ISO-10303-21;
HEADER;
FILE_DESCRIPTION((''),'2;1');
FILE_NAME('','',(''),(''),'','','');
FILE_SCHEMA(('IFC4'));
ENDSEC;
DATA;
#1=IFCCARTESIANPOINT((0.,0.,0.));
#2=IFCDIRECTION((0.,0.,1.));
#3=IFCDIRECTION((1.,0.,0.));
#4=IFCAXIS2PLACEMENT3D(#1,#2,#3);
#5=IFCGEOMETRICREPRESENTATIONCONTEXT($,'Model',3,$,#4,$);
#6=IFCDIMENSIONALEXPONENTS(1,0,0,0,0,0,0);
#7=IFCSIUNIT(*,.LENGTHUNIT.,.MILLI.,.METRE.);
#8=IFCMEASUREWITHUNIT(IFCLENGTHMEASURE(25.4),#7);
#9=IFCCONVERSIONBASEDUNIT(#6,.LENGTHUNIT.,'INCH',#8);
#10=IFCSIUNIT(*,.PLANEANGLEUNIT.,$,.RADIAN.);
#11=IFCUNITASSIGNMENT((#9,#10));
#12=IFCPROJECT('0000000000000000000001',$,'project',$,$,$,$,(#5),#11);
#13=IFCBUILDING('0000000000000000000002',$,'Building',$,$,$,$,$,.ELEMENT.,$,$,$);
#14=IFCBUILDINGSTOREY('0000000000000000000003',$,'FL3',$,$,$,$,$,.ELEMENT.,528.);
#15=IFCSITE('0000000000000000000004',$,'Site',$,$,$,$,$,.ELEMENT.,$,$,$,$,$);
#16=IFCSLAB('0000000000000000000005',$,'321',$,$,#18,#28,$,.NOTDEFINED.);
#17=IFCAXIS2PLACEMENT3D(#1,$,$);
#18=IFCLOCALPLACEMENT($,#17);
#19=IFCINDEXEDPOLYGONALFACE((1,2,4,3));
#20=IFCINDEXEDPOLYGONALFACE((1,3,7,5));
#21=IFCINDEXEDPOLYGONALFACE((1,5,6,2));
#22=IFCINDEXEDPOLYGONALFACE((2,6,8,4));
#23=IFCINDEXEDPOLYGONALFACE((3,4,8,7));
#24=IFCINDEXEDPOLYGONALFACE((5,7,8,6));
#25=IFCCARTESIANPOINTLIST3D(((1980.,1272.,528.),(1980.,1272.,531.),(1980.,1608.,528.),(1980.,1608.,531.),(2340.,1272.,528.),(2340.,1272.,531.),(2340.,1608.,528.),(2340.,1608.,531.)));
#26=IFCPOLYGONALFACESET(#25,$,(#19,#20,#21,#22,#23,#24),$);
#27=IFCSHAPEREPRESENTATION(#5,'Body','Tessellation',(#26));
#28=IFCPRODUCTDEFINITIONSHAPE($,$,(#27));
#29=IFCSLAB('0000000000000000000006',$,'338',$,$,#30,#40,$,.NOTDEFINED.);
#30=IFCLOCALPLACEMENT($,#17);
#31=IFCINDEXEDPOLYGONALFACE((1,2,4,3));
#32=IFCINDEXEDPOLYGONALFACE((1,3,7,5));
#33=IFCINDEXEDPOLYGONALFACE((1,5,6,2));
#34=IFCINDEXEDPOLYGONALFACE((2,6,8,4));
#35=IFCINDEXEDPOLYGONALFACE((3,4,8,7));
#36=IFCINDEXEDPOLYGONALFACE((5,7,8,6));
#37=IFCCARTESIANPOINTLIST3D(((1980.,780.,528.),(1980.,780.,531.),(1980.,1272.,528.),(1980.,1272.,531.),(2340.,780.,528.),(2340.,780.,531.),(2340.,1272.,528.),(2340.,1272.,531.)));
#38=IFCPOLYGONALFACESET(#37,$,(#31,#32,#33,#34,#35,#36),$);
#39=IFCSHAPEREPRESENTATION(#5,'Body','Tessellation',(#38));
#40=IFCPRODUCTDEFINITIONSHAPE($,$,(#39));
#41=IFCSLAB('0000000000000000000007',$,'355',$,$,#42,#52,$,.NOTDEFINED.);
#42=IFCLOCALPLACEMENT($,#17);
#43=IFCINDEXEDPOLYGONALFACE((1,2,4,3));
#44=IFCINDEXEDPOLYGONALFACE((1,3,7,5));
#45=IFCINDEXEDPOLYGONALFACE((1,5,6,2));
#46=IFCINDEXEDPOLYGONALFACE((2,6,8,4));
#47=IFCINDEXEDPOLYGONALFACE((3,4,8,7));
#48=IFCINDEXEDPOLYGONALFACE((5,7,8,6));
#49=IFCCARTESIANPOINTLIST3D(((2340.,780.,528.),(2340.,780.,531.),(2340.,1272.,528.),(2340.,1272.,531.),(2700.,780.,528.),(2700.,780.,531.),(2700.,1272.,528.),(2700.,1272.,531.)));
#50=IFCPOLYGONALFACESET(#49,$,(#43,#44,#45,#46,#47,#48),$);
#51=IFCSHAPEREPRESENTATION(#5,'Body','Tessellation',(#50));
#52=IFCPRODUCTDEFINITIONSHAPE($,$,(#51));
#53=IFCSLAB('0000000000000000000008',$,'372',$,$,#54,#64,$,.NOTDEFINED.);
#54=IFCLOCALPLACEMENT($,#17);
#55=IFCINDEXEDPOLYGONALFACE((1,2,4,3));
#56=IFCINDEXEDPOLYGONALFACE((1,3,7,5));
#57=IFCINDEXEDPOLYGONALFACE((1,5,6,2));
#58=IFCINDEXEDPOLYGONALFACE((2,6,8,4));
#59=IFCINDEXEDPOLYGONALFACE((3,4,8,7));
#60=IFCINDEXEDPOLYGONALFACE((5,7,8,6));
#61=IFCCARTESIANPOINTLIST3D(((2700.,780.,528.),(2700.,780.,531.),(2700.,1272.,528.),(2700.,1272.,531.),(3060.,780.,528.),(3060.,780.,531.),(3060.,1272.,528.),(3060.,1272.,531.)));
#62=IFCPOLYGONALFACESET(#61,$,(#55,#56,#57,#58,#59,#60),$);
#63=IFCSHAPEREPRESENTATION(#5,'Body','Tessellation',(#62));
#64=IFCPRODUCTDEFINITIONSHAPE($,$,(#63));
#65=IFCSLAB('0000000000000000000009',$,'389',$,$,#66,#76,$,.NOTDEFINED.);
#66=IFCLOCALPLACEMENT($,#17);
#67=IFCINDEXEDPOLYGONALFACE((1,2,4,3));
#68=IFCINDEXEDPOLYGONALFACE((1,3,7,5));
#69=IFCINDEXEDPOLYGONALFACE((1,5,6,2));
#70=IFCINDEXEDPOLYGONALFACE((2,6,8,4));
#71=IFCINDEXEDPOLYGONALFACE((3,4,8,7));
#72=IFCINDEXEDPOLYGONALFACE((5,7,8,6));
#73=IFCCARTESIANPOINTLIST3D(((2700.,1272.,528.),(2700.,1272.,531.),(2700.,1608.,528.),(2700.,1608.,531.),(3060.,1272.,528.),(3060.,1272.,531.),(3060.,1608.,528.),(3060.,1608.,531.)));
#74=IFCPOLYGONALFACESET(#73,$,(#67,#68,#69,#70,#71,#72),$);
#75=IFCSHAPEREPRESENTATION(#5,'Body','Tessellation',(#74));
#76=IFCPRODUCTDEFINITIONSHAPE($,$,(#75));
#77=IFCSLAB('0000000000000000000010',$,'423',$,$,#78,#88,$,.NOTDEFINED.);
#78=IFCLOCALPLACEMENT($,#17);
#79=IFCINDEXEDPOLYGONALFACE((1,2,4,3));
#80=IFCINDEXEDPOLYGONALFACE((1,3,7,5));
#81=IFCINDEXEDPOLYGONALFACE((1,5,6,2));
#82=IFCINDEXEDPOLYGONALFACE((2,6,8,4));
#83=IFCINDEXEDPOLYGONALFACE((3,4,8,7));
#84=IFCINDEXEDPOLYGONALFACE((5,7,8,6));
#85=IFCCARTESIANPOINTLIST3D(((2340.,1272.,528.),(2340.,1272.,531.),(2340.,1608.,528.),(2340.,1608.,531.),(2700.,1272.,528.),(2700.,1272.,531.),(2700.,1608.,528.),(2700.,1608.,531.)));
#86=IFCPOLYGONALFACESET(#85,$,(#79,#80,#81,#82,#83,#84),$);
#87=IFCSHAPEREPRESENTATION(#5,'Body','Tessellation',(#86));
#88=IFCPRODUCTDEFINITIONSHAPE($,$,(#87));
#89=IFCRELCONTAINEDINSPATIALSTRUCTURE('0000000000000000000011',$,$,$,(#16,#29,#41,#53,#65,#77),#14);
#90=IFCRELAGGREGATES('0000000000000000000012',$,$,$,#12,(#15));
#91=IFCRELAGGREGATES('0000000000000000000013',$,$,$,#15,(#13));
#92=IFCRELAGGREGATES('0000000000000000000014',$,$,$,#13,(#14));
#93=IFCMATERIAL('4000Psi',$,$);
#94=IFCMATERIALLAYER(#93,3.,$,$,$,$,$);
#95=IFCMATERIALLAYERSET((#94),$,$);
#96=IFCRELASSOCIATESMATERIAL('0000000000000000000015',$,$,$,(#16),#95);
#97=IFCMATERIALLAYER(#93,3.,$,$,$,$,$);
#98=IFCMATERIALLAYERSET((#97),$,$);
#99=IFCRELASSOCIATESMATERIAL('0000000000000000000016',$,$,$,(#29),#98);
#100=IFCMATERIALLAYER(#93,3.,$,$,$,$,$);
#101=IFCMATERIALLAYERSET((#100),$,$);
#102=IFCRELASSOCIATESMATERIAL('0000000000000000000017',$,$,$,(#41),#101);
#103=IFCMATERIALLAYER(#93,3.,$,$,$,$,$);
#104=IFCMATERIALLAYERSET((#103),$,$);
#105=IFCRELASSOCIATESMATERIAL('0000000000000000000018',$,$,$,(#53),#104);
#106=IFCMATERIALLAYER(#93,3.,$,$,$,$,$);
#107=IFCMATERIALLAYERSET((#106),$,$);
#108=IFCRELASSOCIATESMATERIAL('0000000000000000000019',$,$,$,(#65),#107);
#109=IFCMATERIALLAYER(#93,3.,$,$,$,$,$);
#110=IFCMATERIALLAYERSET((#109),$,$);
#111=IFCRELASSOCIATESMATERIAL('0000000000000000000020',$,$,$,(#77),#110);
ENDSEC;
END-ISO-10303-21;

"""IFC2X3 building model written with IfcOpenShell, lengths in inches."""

from ifc_helpers import new_model, entity, si_unit, converted_unit, frame, origin_with_axes, place, context, project, spatial, polyline, outline, extrude, material, layer, layer_set, layer_usage, element, save


model = new_model("IFC2X3")

# Units and contexts
model_context = context("Model", 3, world=origin_with_axes())
ifc_project = project(units=[converted_unit("LENGTHUNIT", "INCH", entity("IfcLengthMeasure", 25.4), si_unit("LENGTHUNIT", "METRE", prefix="MILLI"), dimensions=[1, 0, 0, 0, 0, 0, 0]), si_unit("PLANEANGLEUNIT", "RADIAN")], contexts=[model_context])

# Site, building, storey
site = spatial("IfcSite", under=ifc_project, Name="Site", CompositionType="ELEMENT")
building = spatial("IfcBuilding", under=site, Name="Building", CompositionType="ELEMENT")
storey = spatial("IfcBuildingStorey", under=building, Name="FL3", CompositionType="ELEMENT", Elevation=528.0)

# Slabs
ifc_material_1 = material(Name="4000Psi")
ifc_layer_1 = layer(ifc_material_1, 3.0)
ifc_layer_set_1 = layer_set([ifc_layer_1])
ifc_layer_usage_1 = layer_usage(ifc_layer_set_1, "AXIS2", "POSITIVE", -3.0)
slab_1_placement = place(None, frame((1980.0, 1272.0, 528.0), z_axis=(0.0, 0.0, 1.0), x_axis=(1.0, 0.0, 0.0)))
element("IfcSlab", 1, at=slab_1_placement, inside=storey, material=ifc_layer_usage_1, Name="321", PredefinedType="NOTDEFINED", context=model_context, shape_type="SweptSolid", body=[
    extrude(outline(polyline([(0.0, 0.0), (360.0, 0.0), (360.0, 336.0), (0.0, 336.0), (0.0, 0.0)])), origin_with_axes(), (0.0, 0.0, 1.0), 3.0),
])
ifc_layer_2 = layer(ifc_material_1, 3.0)
ifc_layer_set_2 = layer_set([ifc_layer_2])
ifc_layer_usage_2 = layer_usage(ifc_layer_set_2, "AXIS2", "POSITIVE", -3.0)
slab_2_placement = place(None, frame((1980.0, 780.0, 528.0), z_axis=(0.0, 0.0, 1.0), x_axis=(1.0, 0.0, 0.0)))
element("IfcSlab", 2, at=slab_2_placement, inside=storey, material=ifc_layer_usage_2, Name="338", PredefinedType="NOTDEFINED", context=model_context, shape_type="SweptSolid", body=[
    extrude(outline(polyline([(0.0, 0.0), (360.0, 0.0), (360.0, 492.0), (0.0, 492.0), (0.0, 0.0)])), origin_with_axes(), (0.0, 0.0, 1.0), 3.0),
])
ifc_layer_3 = layer(ifc_material_1, 3.0)
ifc_layer_set_3 = layer_set([ifc_layer_3])
ifc_layer_usage_3 = layer_usage(ifc_layer_set_3, "AXIS2", "POSITIVE", -3.0)
slab_3_placement = place(None, frame((2340.0, 780.0, 528.0), z_axis=(0.0, 0.0, 1.0), x_axis=(1.0, 0.0, 0.0)))
element("IfcSlab", 3, at=slab_3_placement, inside=storey, material=ifc_layer_usage_3, Name="355", PredefinedType="NOTDEFINED", context=model_context, shape_type="SweptSolid", body=[
    extrude(outline(polyline([(0.0, 0.0), (360.0, 0.0), (360.0, 492.0), (0.0, 492.0), (0.0, 0.0)])), origin_with_axes(), (0.0, 0.0, 1.0), 3.0),
])
ifc_layer_4 = layer(ifc_material_1, 3.0)
ifc_layer_set_4 = layer_set([ifc_layer_4])
ifc_layer_usage_4 = layer_usage(ifc_layer_set_4, "AXIS2", "POSITIVE", -3.0)
slab_4_placement = place(None, frame((2700.0, 780.0, 528.0), z_axis=(0.0, 0.0, 1.0), x_axis=(1.0, 0.0, 0.0)))
element("IfcSlab", 4, at=slab_4_placement, inside=storey, material=ifc_layer_usage_4, Name="372", PredefinedType="NOTDEFINED", context=model_context, shape_type="SweptSolid", body=[
    extrude(outline(polyline([(0.0, 0.0), (360.0, 0.0), (360.0, 492.0), (0.0, 492.0), (0.0, 0.0)])), origin_with_axes(), (0.0, 0.0, 1.0), 3.0),
])
ifc_layer_5 = layer(ifc_material_1, 3.0)
ifc_layer_set_5 = layer_set([ifc_layer_5])
ifc_layer_usage_5 = layer_usage(ifc_layer_set_5, "AXIS2", "POSITIVE", -3.0)
slab_5_placement = place(None, frame((2700.0, 1272.0, 528.0), z_axis=(0.0, 0.0, 1.0), x_axis=(1.0, 0.0, 0.0)))
element("IfcSlab", 5, at=slab_5_placement, inside=storey, material=ifc_layer_usage_5, Name="389", PredefinedType="NOTDEFINED", context=model_context, shape_type="SweptSolid", body=[
    extrude(outline(polyline([(0.0, 0.0), (360.0, 0.0), (360.0, 336.0), (0.0, 336.0), (0.0, 0.0)])), origin_with_axes(), (0.0, 0.0, 1.0), 3.0),
])
ifc_layer_6 = layer(ifc_material_1, 3.0)
ifc_layer_set_6 = layer_set([ifc_layer_6])
ifc_layer_usage_6 = layer_usage(ifc_layer_set_6, "AXIS2", "POSITIVE", -3.0)
slab_6_placement = place(None, frame((2340.0, 1272.0, 528.0), z_axis=(0.0, 0.0, 1.0), x_axis=(1.0, 0.0, 0.0)))
element("IfcSlab", 6, at=slab_6_placement, inside=storey, material=ifc_layer_usage_6, Name="423", PredefinedType="NOTDEFINED", context=model_context, shape_type="SweptSolid", body=[
    extrude(outline(polyline([(0.0, 0.0), (360.0, 0.0), (360.0, 336.0), (0.0, 336.0), (0.0, 0.0)])), origin_with_axes(), (0.0, 0.0, 1.0), 3.0),
])

save(model, "model.ifc")
